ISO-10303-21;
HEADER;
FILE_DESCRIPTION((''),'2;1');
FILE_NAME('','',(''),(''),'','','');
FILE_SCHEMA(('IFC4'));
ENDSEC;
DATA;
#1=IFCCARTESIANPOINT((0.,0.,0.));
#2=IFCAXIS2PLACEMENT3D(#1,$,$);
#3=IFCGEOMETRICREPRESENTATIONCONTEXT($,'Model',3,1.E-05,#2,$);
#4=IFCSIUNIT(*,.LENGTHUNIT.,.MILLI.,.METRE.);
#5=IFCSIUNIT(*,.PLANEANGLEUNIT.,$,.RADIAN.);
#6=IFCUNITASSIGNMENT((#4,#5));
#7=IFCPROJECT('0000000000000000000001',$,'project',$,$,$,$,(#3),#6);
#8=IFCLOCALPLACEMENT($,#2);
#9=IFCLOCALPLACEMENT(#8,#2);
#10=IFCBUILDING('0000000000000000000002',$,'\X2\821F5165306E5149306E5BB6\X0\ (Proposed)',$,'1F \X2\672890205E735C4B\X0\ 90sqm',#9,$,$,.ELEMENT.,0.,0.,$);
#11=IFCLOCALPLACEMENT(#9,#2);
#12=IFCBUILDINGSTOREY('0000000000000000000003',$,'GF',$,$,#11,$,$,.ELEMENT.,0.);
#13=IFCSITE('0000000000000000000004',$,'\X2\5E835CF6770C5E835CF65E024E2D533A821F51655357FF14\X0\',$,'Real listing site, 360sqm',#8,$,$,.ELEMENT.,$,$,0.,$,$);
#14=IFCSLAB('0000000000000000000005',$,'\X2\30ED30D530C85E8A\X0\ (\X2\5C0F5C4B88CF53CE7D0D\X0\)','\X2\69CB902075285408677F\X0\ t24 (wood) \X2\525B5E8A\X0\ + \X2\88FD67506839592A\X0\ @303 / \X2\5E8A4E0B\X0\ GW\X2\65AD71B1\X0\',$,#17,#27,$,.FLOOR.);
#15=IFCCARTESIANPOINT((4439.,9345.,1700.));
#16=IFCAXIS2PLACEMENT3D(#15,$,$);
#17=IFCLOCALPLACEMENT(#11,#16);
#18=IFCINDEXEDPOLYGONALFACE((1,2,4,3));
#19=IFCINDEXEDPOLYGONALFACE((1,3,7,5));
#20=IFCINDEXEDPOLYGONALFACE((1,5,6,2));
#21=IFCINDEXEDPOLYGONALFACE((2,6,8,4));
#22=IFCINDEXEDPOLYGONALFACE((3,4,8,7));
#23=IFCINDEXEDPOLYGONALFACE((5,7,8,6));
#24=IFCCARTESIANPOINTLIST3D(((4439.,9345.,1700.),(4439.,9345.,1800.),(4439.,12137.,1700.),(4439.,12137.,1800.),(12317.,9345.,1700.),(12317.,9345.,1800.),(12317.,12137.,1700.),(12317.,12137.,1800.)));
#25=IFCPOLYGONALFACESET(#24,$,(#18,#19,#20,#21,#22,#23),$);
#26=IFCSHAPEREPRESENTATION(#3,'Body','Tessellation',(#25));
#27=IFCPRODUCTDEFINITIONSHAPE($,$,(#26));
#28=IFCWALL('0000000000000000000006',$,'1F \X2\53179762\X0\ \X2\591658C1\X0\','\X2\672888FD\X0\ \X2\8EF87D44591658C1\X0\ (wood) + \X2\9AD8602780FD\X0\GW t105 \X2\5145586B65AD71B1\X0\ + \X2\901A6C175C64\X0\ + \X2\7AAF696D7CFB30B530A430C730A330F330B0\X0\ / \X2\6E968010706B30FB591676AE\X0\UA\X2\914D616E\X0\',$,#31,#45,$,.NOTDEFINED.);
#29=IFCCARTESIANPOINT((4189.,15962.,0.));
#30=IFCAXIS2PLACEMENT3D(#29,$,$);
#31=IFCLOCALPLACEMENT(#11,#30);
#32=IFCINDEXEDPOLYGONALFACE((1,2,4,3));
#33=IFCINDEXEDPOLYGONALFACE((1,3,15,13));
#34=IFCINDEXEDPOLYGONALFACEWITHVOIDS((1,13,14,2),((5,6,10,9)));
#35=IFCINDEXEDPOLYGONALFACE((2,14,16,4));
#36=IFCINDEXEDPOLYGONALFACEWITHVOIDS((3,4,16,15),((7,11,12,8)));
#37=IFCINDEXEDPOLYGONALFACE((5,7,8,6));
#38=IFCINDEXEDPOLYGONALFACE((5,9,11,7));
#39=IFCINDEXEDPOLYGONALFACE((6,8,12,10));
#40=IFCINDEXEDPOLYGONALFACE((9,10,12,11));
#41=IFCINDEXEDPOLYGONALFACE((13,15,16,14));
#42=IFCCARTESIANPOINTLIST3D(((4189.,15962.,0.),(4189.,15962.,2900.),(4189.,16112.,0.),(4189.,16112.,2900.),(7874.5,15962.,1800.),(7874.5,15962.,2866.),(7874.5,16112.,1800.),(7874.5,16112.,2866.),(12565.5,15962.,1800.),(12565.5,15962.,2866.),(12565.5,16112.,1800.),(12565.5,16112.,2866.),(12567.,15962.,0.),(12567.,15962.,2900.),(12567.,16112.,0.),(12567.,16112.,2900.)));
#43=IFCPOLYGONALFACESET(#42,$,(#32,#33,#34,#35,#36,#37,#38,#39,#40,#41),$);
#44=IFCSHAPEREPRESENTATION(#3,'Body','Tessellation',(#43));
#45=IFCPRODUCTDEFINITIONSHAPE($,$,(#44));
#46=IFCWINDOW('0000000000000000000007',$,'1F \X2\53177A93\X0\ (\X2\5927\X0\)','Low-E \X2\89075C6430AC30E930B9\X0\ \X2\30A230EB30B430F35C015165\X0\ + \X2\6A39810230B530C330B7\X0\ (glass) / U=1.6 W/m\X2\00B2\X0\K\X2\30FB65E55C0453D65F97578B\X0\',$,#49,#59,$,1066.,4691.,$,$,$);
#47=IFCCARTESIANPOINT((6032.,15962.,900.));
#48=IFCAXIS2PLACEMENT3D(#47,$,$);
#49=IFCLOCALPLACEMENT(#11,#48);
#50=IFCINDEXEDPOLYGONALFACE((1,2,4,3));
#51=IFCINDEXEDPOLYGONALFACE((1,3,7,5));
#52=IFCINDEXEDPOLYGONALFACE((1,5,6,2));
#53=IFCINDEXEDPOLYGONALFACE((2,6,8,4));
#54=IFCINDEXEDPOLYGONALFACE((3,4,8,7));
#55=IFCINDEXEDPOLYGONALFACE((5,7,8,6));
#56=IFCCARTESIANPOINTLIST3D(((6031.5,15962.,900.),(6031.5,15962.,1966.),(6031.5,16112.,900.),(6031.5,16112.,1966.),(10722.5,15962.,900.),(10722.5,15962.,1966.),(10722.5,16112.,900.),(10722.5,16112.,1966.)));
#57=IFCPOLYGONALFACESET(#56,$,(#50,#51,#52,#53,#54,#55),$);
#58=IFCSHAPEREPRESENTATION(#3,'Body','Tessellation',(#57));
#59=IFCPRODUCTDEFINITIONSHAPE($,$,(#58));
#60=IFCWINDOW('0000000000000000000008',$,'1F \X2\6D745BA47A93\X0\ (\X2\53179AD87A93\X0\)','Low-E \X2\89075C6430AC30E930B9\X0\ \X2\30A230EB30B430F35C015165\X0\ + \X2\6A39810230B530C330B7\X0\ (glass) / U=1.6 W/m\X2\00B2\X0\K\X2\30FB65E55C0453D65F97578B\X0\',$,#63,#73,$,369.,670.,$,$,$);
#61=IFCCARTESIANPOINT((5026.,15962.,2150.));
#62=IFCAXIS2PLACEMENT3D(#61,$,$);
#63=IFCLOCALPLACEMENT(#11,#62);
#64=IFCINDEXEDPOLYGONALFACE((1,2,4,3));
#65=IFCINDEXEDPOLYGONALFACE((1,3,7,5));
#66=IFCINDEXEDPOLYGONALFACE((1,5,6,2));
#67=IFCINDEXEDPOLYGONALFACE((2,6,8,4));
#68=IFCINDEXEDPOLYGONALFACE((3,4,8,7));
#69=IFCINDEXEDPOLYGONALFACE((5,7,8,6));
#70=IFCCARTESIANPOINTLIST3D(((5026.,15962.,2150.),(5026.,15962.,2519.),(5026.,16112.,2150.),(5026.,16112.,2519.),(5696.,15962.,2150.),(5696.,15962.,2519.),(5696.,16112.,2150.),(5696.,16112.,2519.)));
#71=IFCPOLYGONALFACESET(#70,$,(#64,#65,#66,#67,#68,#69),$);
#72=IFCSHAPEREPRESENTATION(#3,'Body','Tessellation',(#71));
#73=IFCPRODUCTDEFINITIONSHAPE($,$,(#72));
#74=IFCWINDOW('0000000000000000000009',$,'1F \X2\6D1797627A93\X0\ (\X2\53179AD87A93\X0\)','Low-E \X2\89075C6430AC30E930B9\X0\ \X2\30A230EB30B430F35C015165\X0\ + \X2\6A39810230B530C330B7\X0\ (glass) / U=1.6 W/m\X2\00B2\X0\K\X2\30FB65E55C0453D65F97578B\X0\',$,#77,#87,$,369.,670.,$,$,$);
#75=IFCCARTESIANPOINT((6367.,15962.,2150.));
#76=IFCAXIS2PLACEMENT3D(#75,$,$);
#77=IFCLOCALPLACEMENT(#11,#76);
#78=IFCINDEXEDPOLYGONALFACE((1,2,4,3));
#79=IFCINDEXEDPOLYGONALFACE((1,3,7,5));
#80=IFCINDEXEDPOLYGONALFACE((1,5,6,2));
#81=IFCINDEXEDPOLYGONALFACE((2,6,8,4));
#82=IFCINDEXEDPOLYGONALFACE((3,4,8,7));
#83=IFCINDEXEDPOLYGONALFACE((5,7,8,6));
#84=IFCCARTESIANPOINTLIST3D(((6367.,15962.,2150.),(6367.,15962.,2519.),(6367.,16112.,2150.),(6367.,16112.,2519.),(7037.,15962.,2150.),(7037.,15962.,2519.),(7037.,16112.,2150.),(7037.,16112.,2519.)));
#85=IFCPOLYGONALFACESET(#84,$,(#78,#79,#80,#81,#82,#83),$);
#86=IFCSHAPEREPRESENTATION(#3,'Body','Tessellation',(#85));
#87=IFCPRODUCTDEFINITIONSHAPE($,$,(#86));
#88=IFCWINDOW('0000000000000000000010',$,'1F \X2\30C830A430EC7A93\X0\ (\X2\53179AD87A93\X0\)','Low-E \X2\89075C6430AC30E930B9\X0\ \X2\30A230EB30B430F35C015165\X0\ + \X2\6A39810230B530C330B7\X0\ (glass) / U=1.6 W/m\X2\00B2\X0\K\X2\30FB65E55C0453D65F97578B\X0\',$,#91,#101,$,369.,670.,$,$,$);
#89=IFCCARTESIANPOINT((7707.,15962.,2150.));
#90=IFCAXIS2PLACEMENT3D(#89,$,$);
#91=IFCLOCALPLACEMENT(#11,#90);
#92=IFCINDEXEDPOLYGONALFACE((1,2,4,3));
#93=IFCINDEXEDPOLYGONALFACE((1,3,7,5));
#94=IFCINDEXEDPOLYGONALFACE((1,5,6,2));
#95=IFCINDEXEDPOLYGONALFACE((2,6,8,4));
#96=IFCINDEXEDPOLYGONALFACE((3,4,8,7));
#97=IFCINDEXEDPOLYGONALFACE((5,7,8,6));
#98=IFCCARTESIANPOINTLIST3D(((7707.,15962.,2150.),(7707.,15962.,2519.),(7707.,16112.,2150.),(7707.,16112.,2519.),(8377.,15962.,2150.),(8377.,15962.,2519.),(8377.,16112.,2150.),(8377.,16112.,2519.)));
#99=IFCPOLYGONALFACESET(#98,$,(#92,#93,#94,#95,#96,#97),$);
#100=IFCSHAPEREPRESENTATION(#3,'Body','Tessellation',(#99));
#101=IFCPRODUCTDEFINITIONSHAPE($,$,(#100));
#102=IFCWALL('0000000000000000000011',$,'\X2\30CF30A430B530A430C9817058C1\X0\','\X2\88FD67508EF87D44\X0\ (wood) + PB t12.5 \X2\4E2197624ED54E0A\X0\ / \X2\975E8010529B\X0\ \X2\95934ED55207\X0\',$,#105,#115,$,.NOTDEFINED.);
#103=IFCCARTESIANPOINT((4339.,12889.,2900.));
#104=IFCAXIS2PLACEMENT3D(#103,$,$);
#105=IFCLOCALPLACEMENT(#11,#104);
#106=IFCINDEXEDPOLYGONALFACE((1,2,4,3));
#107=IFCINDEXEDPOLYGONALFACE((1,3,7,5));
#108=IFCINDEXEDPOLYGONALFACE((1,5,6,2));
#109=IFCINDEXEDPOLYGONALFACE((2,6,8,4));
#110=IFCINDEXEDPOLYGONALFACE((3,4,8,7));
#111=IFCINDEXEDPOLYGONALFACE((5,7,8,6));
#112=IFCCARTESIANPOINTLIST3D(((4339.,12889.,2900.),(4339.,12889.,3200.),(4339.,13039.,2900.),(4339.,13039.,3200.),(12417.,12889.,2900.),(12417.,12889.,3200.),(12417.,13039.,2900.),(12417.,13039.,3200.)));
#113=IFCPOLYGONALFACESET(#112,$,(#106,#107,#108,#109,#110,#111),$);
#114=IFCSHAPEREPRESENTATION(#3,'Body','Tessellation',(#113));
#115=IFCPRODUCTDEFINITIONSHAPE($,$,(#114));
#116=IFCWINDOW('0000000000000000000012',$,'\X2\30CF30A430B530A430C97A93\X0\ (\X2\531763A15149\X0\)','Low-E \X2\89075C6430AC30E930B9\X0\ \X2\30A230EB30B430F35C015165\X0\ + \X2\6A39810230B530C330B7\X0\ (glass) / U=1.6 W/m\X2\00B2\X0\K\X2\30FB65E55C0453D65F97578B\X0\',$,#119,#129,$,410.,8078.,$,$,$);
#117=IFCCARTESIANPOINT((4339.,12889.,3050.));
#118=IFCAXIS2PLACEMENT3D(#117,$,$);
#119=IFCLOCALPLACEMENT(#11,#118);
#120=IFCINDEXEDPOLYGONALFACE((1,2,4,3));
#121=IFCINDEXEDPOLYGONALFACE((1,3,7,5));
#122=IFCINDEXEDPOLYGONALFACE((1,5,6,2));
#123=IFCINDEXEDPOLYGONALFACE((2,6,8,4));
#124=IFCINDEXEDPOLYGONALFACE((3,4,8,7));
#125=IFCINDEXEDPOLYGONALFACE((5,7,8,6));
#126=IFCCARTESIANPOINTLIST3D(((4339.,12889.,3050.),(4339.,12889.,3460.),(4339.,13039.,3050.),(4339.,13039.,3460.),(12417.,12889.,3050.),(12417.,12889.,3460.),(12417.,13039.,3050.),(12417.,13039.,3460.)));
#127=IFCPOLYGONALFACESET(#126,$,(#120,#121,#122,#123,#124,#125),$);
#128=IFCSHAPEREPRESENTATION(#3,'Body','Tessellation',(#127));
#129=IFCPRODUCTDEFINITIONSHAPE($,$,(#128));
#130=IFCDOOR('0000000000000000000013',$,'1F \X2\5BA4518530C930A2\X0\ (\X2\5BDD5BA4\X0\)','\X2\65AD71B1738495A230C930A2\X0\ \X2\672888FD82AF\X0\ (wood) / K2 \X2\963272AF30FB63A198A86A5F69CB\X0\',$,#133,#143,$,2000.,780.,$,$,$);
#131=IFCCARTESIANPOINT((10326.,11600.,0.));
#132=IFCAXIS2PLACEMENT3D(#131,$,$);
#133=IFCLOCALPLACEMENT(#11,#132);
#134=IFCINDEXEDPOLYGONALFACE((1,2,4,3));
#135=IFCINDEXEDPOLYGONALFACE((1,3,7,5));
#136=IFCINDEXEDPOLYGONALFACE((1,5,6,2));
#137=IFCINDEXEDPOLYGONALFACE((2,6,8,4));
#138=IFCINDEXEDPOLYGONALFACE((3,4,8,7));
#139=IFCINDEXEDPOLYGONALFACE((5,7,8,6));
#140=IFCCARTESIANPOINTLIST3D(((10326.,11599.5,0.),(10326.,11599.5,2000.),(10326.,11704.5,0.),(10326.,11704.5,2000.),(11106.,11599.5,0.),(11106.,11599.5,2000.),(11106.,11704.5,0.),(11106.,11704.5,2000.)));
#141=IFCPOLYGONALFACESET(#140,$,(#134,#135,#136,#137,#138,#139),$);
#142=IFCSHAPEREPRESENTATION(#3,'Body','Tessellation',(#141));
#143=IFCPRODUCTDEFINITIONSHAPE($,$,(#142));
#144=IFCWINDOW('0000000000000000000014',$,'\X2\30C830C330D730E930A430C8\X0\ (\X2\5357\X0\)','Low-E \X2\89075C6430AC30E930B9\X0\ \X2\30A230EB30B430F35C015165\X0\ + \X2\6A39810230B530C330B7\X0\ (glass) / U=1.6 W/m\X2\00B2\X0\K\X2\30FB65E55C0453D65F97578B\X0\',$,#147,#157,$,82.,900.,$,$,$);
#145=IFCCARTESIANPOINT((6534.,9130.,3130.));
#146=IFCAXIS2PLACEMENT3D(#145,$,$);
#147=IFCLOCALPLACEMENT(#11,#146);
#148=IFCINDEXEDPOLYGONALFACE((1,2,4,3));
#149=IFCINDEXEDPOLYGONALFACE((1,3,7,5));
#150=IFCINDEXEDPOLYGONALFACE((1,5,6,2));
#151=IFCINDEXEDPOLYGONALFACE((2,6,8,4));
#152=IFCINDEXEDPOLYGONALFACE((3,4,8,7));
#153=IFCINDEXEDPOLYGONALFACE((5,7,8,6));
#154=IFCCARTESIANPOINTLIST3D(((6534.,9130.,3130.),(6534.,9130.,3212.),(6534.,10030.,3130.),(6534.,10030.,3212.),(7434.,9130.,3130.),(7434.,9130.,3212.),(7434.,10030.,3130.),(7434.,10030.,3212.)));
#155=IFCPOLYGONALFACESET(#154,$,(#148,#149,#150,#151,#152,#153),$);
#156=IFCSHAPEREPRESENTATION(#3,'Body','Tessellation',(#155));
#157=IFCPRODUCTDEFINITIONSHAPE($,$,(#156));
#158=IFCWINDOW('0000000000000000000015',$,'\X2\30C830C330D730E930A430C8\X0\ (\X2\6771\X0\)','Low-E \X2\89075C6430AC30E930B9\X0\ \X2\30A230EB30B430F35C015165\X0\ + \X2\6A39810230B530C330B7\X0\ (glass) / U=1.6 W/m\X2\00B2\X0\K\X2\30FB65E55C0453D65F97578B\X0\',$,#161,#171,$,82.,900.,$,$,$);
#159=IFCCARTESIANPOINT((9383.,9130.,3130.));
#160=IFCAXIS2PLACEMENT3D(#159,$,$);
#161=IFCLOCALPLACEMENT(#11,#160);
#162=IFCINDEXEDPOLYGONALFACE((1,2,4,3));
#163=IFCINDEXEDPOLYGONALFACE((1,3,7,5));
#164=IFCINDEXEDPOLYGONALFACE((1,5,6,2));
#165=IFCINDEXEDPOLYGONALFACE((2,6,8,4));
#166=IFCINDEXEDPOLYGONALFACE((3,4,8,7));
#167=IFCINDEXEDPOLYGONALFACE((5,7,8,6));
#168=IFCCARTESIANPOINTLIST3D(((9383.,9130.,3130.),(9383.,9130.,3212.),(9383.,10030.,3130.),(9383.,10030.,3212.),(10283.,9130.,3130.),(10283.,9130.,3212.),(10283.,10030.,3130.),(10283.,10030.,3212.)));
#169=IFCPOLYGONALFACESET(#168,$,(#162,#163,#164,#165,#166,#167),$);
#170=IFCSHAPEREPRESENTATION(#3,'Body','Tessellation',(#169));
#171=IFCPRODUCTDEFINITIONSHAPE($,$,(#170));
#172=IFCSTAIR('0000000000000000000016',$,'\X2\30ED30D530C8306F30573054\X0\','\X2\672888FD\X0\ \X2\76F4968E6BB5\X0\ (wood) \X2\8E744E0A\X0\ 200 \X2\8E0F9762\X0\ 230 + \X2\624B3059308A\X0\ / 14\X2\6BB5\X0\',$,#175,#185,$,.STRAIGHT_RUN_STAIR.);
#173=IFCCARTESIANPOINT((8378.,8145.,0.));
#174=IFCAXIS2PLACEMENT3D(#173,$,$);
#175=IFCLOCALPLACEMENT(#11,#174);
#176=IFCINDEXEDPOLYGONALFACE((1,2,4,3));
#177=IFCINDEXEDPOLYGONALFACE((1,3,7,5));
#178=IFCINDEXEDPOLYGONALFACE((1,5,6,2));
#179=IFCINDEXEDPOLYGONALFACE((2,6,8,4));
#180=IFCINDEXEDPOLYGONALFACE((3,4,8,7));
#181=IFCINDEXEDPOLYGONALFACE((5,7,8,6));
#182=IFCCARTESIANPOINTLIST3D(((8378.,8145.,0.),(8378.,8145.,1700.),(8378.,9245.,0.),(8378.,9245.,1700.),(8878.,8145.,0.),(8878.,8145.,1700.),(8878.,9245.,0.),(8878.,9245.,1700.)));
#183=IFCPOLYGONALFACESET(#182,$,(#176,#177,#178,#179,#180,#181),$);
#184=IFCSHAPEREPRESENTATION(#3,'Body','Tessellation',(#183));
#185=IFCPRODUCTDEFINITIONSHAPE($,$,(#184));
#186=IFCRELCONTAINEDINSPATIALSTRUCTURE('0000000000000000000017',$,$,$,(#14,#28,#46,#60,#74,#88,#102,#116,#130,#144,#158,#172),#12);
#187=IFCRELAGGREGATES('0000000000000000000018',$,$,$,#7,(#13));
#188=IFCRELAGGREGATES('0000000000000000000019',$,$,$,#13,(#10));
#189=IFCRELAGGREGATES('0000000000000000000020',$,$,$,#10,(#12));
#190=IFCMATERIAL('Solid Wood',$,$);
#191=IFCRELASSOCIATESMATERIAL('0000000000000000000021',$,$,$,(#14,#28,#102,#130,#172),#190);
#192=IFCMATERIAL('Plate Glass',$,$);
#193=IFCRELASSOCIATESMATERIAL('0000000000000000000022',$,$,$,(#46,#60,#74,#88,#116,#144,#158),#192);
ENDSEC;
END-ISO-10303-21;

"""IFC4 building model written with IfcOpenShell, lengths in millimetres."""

from ifc_helpers import new_model, si_unit, frame, frame_2d, origin, place, context, project, spatial, rectangle, extrude, material, element, fill, save


model = new_model("IFC4")

# Units and contexts
model_context = context("Model", 3, precision=1e-05, world=origin())
ifc_project = project(units=[si_unit("LENGTHUNIT", "METRE", prefix="MILLI"), si_unit("PLANEANGLEUNIT", "RADIAN")], contexts=[model_context])

# Site, building, storey
site_placement = place(None, origin())
site = spatial("IfcSite", under=ifc_project, at=site_placement, Name="広島県広島市中区舟入南４", ObjectType="Real listing site, 360sqm", CompositionType="ELEMENT", RefElevation=0.0)
building_placement = place(site_placement, origin())
building = spatial("IfcBuilding", under=site, at=building_placement, Name="舟入の光の家 (Proposed)", ObjectType="1F 木造平屋 90sqm", CompositionType="ELEMENT", ElevationOfRefHeight=0.0, ElevationOfTerrain=0.0)
storey_placement = place(building_placement, origin())
storey = spatial("IfcBuildingStorey", under=building, at=storey_placement, Name="GF", CompositionType="ELEMENT", Elevation=0.0)

# Slab
ifc_material_1 = material(Name="Solid Wood")
slab_placement = place(storey_placement, frame((4439.0, 9345.0, 1700.0)))
element("IfcSlab", 1, at=slab_placement, inside=storey, material=ifc_material_1, Name="ロフト床 (小屋裏収納)", Description="構造用合板 t24 (wood) 剛床 + 製材根太 @303 / 床下 GW断熱", PredefinedType="FLOOR", context=model_context, shape_type="SweptSolid", body=[
    extrude(rectangle(XDim=7878.0, YDim=2792.0, at=frame_2d((3939.0, 1396.0))), frame((4439.0, 9345.0, 1700.0)), (0.0, 0.0, 1.0), 100.0),
])

# Wall, openings, windows
wall_1_placement = place(storey_placement, frame((4189.0, 15962.0, 0.0)))
wall_1 = element("IfcWall", 2, at=wall_1_placement, inside=storey, material=ifc_material_1, Name="1F 北面 外壁", Description="木製 軸組外壁 (wood) + 高性能GW t105 充填断熱 + 通気層 + 窯業系サイディング / 準耐火・外皮UA配慮", PredefinedType="NOTDEFINED", context=model_context, shape_type="SweptSolid", body=[
    extrude(rectangle(XDim=8378.0, YDim=150.0, at=frame_2d((4189.0, 75.0))), frame((4189.0, 15962.0, 0.0)), (0.0, 0.0, 1.0), 2900.0),
])
opening_1_placement = place(storey_placement, frame((6032.0, 15962.0, 900.0)))
opening_1 = element("IfcOpeningElement", 3, at=opening_1_placement, cuts=wall_1, PredefinedType="NOTDEFINED", context=model_context, shape_type="SweptSolid", body=[
    extrude(rectangle(XDim=4691.0, YDim=150.0, at=frame_2d((2345.0, 75.0))), frame((6032.0, 15962.0, 900.0)), (0.0, 0.0, 1.0), 1066.0),
])
opening_2_placement = place(storey_placement, frame((5026.0, 15962.0, 2150.0)))
opening_2 = element("IfcOpeningElement", 4, at=opening_2_placement, cuts=wall_1, PredefinedType="NOTDEFINED", context=model_context, shape_type="SweptSolid", body=[
    extrude(rectangle(XDim=670.0, YDim=150.0, at=frame_2d((335.0, 75.0))), frame((5026.0, 15962.0, 2150.0)), (0.0, 0.0, 1.0), 369.0),
])
opening_3_placement = place(storey_placement, frame((6367.0, 15962.0, 2150.0)))
opening_3 = element("IfcOpeningElement", 5, at=opening_3_placement, cuts=wall_1, PredefinedType="NOTDEFINED", context=model_context, shape_type="SweptSolid", body=[
    extrude(rectangle(XDim=670.0, YDim=150.0, at=frame_2d((335.0, 75.0))), frame((6367.0, 15962.0, 2150.0)), (0.0, 0.0, 1.0), 369.0),
])
opening_4_placement = place(storey_placement, frame((7707.0, 15962.0, 2150.0)))
opening_4 = element("IfcOpeningElement", 6, at=opening_4_placement, cuts=wall_1, PredefinedType="NOTDEFINED", context=model_context, shape_type="SweptSolid", body=[
    extrude(rectangle(XDim=670.0, YDim=150.0, at=frame_2d((335.0, 75.0))), frame((7707.0, 15962.0, 2150.0)), (0.0, 0.0, 1.0), 369.0),
])
ifc_material_2 = material(Name="Plate Glass")
window_1_placement = place(storey_placement, frame((6032.0, 15962.0, 900.0)))
window_1 = element("IfcWindow", 7, at=window_1_placement, inside=storey, material=ifc_material_2, Name="1F 北窓 (大)", Description="Low-E 複層ガラス アルゴン封入 + 樹脂サッシ (glass) / U=1.6 W/m²K・日射取得型", OverallHeight=1066.0, OverallWidth=4691.0, context=model_context, shape_type="SweptSolid", body=[
    extrude(rectangle(XDim=4691.0, YDim=150.0, at=frame_2d((2345.0, 75.0))), frame((6032.0, 15962.0, 900.0)), (0.0, 0.0, 1.0), 1066.0),
])
fill(opening_1, window_1)
window_2_placement = place(storey_placement, frame((5026.0, 15962.0, 2150.0)))
window_2 = element("IfcWindow", 8, at=window_2_placement, inside=storey, material=ifc_material_2, Name="1F 浴室窓 (北高窓)", Description="Low-E 複層ガラス アルゴン封入 + 樹脂サッシ (glass) / U=1.6 W/m²K・日射取得型", OverallHeight=369.0, OverallWidth=670.0, context=model_context, shape_type="SweptSolid", body=[
    extrude(rectangle(XDim=670.0, YDim=150.0, at=frame_2d((335.0, 75.0))), frame((5026.0, 15962.0, 2150.0)), (0.0, 0.0, 1.0), 369.0),
])
fill(opening_2, window_2)
window_3_placement = place(storey_placement, frame((6367.0, 15962.0, 2150.0)))
window_3 = element("IfcWindow", 9, at=window_3_placement, inside=storey, material=ifc_material_2, Name="1F 洗面窓 (北高窓)", Description="Low-E 複層ガラス アルゴン封入 + 樹脂サッシ (glass) / U=1.6 W/m²K・日射取得型", OverallHeight=369.0, OverallWidth=670.0, context=model_context, shape_type="SweptSolid", body=[
    extrude(rectangle(XDim=670.0, YDim=150.0, at=frame_2d((335.0, 75.0))), frame((6367.0, 15962.0, 2150.0)), (0.0, 0.0, 1.0), 369.0),
])
fill(opening_3, window_3)
window_4_placement = place(storey_placement, frame((7707.0, 15962.0, 2150.0)))
window_4 = element("IfcWindow", 10, at=window_4_placement, inside=storey, material=ifc_material_2, Name="1F トイレ窓 (北高窓)", Description="Low-E 複層ガラス アルゴン封入 + 樹脂サッシ (glass) / U=1.6 W/m²K・日射取得型", OverallHeight=369.0, OverallWidth=670.0, context=model_context, shape_type="SweptSolid", body=[
    extrude(rectangle(XDim=670.0, YDim=150.0, at=frame_2d((335.0, 75.0))), frame((7707.0, 15962.0, 2150.0)), (0.0, 0.0, 1.0), 369.0),
])
fill(opening_4, window_4)

# Wall, opening, window
wall_2_placement = place(storey_placement, frame((4339.0, 12889.0, 2900.0)))
wall_2 = element("IfcWall", 11, at=wall_2_placement, inside=storey, material=ifc_material_1, Name="ハイサイド腰壁", Description="製材軸組 (wood) + PB t12.5 両面仕上 / 非耐力 間仕切", PredefinedType="NOTDEFINED", context=model_context, shape_type="SweptSolid", body=[
    extrude(rectangle(XDim=8078.0, YDim=150.0, at=frame_2d((4039.0, 75.0))), frame((4339.0, 12889.0, 2900.0)), (0.0, 0.0, 1.0), 700.0),
])
opening_5_placement = place(storey_placement, frame((4339.0, 12889.0, 3050.0)))
opening_5 = element("IfcOpeningElement", 12, at=opening_5_placement, cuts=wall_2, PredefinedType="NOTDEFINED", context=model_context, shape_type="SweptSolid", body=[
    extrude(rectangle(XDim=8078.0, YDim=150.0, at=frame_2d((4039.0, 75.0))), frame((4339.0, 12889.0, 3050.0)), (0.0, 0.0, 1.0), 410.0),
])
window_5_placement = place(storey_placement, frame((4339.0, 12889.0, 3050.0)))
window_5 = element("IfcWindow", 13, at=window_5_placement, inside=storey, material=ifc_material_2, Name="ハイサイド窓 (北採光)", Description="Low-E 複層ガラス アルゴン封入 + 樹脂サッシ (glass) / U=1.6 W/m²K・日射取得型", OverallHeight=410.0, OverallWidth=8078.0, context=model_context, shape_type="SweptSolid", body=[
    extrude(rectangle(XDim=8078.0, YDim=150.0, at=frame_2d((4039.0, 75.0))), frame((4339.0, 12889.0, 3050.0)), (0.0, 0.0, 1.0), 410.0),
])
fill(opening_5, window_5)

# Door
door_1_placement = place(storey_placement, frame((10326.0, 11600.0, 0.0)))
element("IfcDoor", 14, at=door_1_placement, inside=storey, material=ifc_material_1, Name="1F 室内ドア (寝室)", Description="断熱玄関ドア 木製芯 (wood) / K2 防犯・採風機構", OverallHeight=2000.0, OverallWidth=780.0, context=model_context, shape_type="SweptSolid", body=[
    extrude(rectangle(XDim=780.0, YDim=105.0, at=frame_2d((390.0, 52.0))), frame((10326.0, 11600.0, 0.0)), (0.0, 0.0, 1.0), 2000.0),
])

# Windows
window_6_placement = place(storey_placement, frame((6534.0, 9130.0, 3130.0)))
element("IfcWindow", 15, at=window_6_placement, inside=storey, material=ifc_material_2, Name="トップライト (南)", Description="Low-E 複層ガラス アルゴン封入 + 樹脂サッシ (glass) / U=1.6 W/m²K・日射取得型", OverallHeight=82.0, OverallWidth=900.0, context=model_context, shape_type="SweptSolid", body=[
    extrude(rectangle(XDim=900.0, YDim=900.0, at=frame_2d((450.0, 450.0))), frame((6534.0, 9130.0, 3130.0)), (0.0, 0.0, 1.0), 82.0),
])
window_7_placement = place(storey_placement, frame((9383.0, 9130.0, 3130.0)))
element("IfcWindow", 16, at=window_7_placement, inside=storey, material=ifc_material_2, Name="トップライト (東)", Description="Low-E 複層ガラス アルゴン封入 + 樹脂サッシ (glass) / U=1.6 W/m²K・日射取得型", OverallHeight=82.0, OverallWidth=900.0, context=model_context, shape_type="SweptSolid", body=[
    extrude(rectangle(XDim=900.0, YDim=900.0, at=frame_2d((450.0, 450.0))), frame((9383.0, 9130.0, 3130.0)), (0.0, 0.0, 1.0), 82.0),
])

# Stair
stair_placement = place(storey_placement, frame((8378.0, 8145.0, 0.0)))
element("IfcStair", 17, at=stair_placement, inside=storey, material=ifc_material_1, Name="ロフトはしご", Description="木製 直階段 (wood) 蹴上 200 踏面 230 + 手すり / 14段", PredefinedType="STRAIGHT_RUN_STAIR", context=model_context, shape_type="SweptSolid", body=[
    extrude(rectangle(XDim=500.0, YDim=1100.0, at=frame_2d((250.0, 550.0))), frame((8378.0, 8145.0, 0.0)), (0.0, 0.0, 1.0), 1700.0),
])

save(model, "model.ifc")
